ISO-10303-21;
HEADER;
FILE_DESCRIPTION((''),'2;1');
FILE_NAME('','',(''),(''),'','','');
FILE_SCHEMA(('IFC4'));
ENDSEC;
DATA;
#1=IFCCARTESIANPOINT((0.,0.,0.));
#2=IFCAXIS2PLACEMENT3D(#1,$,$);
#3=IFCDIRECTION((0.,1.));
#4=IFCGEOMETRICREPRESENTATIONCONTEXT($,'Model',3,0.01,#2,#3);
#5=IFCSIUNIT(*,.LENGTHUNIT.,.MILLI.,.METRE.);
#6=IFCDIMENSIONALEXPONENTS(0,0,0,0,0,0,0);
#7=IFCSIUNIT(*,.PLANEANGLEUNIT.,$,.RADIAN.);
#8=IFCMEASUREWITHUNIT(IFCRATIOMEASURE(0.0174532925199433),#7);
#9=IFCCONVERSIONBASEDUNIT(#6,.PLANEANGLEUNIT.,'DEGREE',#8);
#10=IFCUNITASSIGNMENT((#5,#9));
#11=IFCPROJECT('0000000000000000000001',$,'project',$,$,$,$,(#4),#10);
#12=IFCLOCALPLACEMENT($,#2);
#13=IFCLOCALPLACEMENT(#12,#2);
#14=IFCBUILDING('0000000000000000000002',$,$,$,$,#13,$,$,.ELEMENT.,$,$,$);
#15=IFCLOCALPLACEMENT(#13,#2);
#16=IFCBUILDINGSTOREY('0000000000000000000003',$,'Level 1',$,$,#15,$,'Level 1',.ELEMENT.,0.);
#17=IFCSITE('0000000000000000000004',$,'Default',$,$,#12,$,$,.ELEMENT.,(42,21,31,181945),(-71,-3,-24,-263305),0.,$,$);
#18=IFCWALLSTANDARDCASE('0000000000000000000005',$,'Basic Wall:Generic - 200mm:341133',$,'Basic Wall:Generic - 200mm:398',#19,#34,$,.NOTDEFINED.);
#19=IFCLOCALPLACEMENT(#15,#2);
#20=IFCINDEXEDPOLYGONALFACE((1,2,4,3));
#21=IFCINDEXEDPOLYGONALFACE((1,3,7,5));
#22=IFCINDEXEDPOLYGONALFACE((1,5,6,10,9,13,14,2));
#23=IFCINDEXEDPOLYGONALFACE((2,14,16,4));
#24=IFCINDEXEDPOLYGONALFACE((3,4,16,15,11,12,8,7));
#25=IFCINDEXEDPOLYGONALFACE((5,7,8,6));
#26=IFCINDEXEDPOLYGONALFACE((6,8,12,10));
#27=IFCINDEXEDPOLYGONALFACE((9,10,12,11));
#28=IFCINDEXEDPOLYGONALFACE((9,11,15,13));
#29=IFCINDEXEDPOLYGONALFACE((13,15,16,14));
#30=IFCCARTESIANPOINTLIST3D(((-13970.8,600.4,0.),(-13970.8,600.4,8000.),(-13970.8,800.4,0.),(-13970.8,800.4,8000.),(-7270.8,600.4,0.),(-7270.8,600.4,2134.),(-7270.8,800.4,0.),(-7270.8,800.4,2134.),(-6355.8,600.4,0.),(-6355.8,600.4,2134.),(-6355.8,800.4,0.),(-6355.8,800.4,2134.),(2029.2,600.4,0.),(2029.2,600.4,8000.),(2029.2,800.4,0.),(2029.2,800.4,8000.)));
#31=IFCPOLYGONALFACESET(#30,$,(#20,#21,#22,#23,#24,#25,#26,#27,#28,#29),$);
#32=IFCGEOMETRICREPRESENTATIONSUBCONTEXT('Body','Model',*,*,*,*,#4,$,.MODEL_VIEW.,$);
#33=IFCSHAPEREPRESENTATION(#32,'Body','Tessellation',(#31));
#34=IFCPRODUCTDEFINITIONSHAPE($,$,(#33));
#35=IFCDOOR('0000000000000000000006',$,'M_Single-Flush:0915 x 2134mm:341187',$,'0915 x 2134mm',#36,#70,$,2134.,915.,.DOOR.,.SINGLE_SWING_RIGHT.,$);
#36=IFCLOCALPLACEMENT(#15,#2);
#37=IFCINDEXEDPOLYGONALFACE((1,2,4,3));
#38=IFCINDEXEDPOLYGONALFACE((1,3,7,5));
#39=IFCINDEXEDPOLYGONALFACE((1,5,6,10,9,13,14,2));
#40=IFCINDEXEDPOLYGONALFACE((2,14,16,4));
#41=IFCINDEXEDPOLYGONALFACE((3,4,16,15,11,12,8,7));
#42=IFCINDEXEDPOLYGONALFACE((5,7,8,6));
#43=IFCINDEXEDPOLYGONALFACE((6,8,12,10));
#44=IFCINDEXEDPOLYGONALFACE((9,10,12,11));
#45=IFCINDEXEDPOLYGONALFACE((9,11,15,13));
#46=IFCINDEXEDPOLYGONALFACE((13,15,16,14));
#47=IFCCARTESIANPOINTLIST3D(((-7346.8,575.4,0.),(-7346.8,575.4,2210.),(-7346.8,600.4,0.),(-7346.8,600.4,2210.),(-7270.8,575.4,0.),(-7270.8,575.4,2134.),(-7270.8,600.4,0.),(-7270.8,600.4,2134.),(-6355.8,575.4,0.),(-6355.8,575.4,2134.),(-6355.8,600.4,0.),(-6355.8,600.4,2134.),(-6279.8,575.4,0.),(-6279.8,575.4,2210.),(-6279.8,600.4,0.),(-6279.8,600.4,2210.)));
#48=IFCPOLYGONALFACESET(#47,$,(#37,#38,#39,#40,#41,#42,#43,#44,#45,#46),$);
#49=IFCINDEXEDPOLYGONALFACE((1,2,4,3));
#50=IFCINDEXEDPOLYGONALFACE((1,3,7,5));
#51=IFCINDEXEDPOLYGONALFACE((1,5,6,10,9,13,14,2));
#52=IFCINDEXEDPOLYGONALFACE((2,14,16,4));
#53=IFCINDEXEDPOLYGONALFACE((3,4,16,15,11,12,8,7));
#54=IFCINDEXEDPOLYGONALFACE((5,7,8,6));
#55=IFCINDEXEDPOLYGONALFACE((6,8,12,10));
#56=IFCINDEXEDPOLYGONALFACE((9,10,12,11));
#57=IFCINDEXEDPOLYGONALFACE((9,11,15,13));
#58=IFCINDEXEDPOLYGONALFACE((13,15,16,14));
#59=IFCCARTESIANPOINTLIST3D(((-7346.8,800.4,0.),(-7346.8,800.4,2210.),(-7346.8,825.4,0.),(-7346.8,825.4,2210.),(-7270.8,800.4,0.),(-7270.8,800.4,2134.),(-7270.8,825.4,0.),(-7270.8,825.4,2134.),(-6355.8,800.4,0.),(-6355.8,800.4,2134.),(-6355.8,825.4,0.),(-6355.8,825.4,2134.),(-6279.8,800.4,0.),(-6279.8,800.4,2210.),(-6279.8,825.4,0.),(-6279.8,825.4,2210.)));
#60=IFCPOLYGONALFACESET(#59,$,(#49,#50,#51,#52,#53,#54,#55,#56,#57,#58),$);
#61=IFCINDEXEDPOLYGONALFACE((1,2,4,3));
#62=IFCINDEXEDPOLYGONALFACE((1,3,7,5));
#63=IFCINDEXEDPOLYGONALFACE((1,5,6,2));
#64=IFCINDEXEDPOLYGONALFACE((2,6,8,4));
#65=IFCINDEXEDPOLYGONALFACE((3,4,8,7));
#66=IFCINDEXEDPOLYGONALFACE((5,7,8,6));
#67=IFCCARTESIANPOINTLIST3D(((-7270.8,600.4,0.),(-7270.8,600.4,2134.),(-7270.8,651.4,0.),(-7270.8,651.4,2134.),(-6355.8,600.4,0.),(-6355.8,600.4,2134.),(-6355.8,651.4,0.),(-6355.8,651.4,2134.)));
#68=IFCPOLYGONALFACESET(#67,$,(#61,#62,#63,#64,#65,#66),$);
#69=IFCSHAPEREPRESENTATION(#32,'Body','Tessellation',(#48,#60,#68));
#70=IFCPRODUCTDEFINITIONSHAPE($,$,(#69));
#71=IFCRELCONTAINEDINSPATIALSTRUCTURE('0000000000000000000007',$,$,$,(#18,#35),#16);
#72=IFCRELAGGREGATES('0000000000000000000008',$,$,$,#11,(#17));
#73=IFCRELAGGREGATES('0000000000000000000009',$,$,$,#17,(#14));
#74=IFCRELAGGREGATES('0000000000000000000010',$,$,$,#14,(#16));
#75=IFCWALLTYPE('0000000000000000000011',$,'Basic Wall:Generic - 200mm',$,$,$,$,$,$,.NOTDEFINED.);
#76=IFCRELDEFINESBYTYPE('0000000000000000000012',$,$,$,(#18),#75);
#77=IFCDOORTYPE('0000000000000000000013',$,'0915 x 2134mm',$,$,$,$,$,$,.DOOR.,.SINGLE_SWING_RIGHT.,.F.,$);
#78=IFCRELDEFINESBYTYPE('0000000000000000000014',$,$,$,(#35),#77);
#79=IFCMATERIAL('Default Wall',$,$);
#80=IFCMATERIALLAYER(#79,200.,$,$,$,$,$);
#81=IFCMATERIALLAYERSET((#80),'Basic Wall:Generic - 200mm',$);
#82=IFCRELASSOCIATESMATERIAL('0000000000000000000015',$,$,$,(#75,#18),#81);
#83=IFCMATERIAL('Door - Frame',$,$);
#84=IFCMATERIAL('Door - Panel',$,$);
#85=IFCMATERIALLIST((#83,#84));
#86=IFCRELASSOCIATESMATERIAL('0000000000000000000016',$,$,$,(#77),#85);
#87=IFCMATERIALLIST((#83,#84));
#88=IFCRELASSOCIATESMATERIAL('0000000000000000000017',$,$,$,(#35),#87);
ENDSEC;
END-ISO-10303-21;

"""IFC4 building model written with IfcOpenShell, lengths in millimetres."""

from ifc_helpers import new_model, entity, si_unit, converted_unit, direction, frame, frame_2d, origin, place, context, subcontext, project, spatial, polyline, rectangle, outline, extrude, source, transform, mapped, material, material_list, layer, layer_set, layer_usage, type_object, type_shapes, element, fill, save


model = new_model("IFC4")

# Units and contexts
model_context = context("Model", 3, precision=0.01, world=origin(), true_north=direction((0.0, 1.0)))
body_context = subcontext(model_context, "Body", "Model", "MODEL_VIEW")
ifc_project = project(units=[si_unit("LENGTHUNIT", "METRE", prefix="MILLI"), converted_unit("PLANEANGLEUNIT", "DEGREE", entity("IfcRatioMeasure", 0.0174532925199433), si_unit("PLANEANGLEUNIT", "RADIAN"), dimensions=[0, 0, 0, 0, 0, 0, 0])], contexts=[model_context])

# Site, building, storey
site_placement = place(None, origin())
site = spatial("IfcSite", under=ifc_project, at=site_placement, Name="Default", CompositionType="ELEMENT", RefLatitude=(42, 21, 31, 181945), RefLongitude=(-71, -3, -24, -263305), RefElevation=0.0)
building_placement = place(site_placement, origin())
building = spatial("IfcBuilding", under=site, at=building_placement, CompositionType="ELEMENT")
storey_placement = place(building_placement, origin())
storey = spatial("IfcBuildingStorey", under=building, at=storey_placement, Name="Level 1", LongName="Level 1", CompositionType="ELEMENT", Elevation=0.0)

# Wall, opening, door
ifc_material_1 = material(Name="Default Wall")
ifc_layer = layer(ifc_material_1, 200.0)
ifc_layer_set = layer_set([ifc_layer], Name="Basic Wall:Generic - 200mm")
ifc_layer_usage = layer_usage(ifc_layer_set, "AXIS2", "NEGATIVE", 100.0)
wall_type = type_object("IfcWallType", Name="Basic Wall:Generic - 200mm", PredefinedType="NOTDEFINED", material=ifc_layer_set)
wall_placement = place(storey_placement, frame((-13970.8, 700.4, 0.0)))
wall = element("IfcWallStandardCase", 1, at=wall_placement, inside=storey, type_object=wall_type, material=ifc_layer_usage, Name="Basic Wall:Generic - 200mm:341133", ObjectType="Basic Wall:Generic - 200mm:398", PredefinedType="NOTDEFINED", context=body_context, shape_type="SweptSolid", body=[
    extrude(rectangle(XDim=16000.0, YDim=200.0, at=frame_2d((8000.0, 0.0), x_axis=(-1.0, 0.0))), origin(), (0.0, 0.0, 1.0), 8000.0),
])
opening_placement = place(wall_placement, frame((7615.0, 100.0, 0.0)))
opening = element("IfcOpeningElement", 2, at=opening_placement, cuts=wall, ObjectType="Opening", PredefinedType="OPENING", context=body_context, shape_type="SweptSolid", body=[
    extrude(rectangle(XDim=915.0, YDim=2134.0, at=frame_2d((1067.0, 457.5), x_axis=(0.0, 1.0))), frame((0.0, 0.0, 0.0), z_axis=(0.0, -1.0, 0.0), x_axis=(0.0, 0.0, 1.0)), (0.0, 0.0, 1.0), 200.0),
])
ifc_material_2 = material(Name="Door - Frame")
ifc_material_3 = material(Name="Door - Panel")
ifc_material_list_1 = material_list([ifc_material_2, ifc_material_3])
ifc_material_list_2 = material_list([ifc_material_2, ifc_material_3])
door_type = type_object("IfcDoorType", Name="0915 x 2134mm", OperationType="SINGLE_SWING_RIGHT", ParameterTakesPrecedence=False, PredefinedType="DOOR", material=ifc_material_list_2)
shared_shape = source(origin(), body_context, "Body", "SweptSolid", [
    extrude(outline(polyline([(-533.5, -1124.0), (533.5, -1124.0), (533.5, 1086.0), (457.5, 1086.0), (457.5, -1048.0), (-457.5, -1048.0), (-457.5, 1086.0), (-533.5, 1086.0), (-533.5, -1124.0)])), frame((457.5, 200.0, 1086.0), z_axis=(0.0, 1.0, 0.0), x_axis=(1.0, 0.0, 0.0)), (0.0, 0.0, 1.0), 25.0),
    extrude(outline(polyline([(-1124.0, -533.5), (1086.0, -533.5), (1086.0, -457.5), (-1048.0, -457.5), (-1048.0, 457.5), (1086.0, 457.5), (1086.0, 533.5), (-1124.0, 533.5), (-1124.0, -533.5)])), frame((457.5, -25.0, 1086.0), z_axis=(0.0, 1.0, 0.0), x_axis=(0.0, 0.0, -1.0)), (0.0, 0.0, 1.0), 25.0),
    extrude(rectangle(XDim=51.0, YDim=915.0, at=frame_2d((0.0, 0.0), x_axis=(1.0, 0.0))), frame((457.5, 174.5, 0.0), z_axis=(0.0, 0.0, 1.0), x_axis=(0.0, 1.0, 0.0)), (0.0, 0.0, 1.0), 2134.0),
])
type_shapes(door_type, [shared_shape])
door_placement = place(opening_placement, frame((0.0, 0.0, 0.0), z_axis=(0.0, 0.0, 1.0), x_axis=(-1.0, 0.0, 0.0)))
door = element("IfcDoor", 3, at=door_placement, inside=storey, type_object=door_type, material=ifc_material_list_1, Name="M_Single-Flush:0915 x 2134mm:341187", ObjectType="0915 x 2134mm", OperationType="SINGLE_SWING_RIGHT", OverallHeight=2134.0, OverallWidth=915.0, PredefinedType="DOOR", context=body_context, shape_type="MappedRepresentation", body=[
    mapped(shared_shape, transform((0.0, 0.0, 0.0), scale=1.0)),
])
fill(opening, door)

save(model, "model.ifc")
